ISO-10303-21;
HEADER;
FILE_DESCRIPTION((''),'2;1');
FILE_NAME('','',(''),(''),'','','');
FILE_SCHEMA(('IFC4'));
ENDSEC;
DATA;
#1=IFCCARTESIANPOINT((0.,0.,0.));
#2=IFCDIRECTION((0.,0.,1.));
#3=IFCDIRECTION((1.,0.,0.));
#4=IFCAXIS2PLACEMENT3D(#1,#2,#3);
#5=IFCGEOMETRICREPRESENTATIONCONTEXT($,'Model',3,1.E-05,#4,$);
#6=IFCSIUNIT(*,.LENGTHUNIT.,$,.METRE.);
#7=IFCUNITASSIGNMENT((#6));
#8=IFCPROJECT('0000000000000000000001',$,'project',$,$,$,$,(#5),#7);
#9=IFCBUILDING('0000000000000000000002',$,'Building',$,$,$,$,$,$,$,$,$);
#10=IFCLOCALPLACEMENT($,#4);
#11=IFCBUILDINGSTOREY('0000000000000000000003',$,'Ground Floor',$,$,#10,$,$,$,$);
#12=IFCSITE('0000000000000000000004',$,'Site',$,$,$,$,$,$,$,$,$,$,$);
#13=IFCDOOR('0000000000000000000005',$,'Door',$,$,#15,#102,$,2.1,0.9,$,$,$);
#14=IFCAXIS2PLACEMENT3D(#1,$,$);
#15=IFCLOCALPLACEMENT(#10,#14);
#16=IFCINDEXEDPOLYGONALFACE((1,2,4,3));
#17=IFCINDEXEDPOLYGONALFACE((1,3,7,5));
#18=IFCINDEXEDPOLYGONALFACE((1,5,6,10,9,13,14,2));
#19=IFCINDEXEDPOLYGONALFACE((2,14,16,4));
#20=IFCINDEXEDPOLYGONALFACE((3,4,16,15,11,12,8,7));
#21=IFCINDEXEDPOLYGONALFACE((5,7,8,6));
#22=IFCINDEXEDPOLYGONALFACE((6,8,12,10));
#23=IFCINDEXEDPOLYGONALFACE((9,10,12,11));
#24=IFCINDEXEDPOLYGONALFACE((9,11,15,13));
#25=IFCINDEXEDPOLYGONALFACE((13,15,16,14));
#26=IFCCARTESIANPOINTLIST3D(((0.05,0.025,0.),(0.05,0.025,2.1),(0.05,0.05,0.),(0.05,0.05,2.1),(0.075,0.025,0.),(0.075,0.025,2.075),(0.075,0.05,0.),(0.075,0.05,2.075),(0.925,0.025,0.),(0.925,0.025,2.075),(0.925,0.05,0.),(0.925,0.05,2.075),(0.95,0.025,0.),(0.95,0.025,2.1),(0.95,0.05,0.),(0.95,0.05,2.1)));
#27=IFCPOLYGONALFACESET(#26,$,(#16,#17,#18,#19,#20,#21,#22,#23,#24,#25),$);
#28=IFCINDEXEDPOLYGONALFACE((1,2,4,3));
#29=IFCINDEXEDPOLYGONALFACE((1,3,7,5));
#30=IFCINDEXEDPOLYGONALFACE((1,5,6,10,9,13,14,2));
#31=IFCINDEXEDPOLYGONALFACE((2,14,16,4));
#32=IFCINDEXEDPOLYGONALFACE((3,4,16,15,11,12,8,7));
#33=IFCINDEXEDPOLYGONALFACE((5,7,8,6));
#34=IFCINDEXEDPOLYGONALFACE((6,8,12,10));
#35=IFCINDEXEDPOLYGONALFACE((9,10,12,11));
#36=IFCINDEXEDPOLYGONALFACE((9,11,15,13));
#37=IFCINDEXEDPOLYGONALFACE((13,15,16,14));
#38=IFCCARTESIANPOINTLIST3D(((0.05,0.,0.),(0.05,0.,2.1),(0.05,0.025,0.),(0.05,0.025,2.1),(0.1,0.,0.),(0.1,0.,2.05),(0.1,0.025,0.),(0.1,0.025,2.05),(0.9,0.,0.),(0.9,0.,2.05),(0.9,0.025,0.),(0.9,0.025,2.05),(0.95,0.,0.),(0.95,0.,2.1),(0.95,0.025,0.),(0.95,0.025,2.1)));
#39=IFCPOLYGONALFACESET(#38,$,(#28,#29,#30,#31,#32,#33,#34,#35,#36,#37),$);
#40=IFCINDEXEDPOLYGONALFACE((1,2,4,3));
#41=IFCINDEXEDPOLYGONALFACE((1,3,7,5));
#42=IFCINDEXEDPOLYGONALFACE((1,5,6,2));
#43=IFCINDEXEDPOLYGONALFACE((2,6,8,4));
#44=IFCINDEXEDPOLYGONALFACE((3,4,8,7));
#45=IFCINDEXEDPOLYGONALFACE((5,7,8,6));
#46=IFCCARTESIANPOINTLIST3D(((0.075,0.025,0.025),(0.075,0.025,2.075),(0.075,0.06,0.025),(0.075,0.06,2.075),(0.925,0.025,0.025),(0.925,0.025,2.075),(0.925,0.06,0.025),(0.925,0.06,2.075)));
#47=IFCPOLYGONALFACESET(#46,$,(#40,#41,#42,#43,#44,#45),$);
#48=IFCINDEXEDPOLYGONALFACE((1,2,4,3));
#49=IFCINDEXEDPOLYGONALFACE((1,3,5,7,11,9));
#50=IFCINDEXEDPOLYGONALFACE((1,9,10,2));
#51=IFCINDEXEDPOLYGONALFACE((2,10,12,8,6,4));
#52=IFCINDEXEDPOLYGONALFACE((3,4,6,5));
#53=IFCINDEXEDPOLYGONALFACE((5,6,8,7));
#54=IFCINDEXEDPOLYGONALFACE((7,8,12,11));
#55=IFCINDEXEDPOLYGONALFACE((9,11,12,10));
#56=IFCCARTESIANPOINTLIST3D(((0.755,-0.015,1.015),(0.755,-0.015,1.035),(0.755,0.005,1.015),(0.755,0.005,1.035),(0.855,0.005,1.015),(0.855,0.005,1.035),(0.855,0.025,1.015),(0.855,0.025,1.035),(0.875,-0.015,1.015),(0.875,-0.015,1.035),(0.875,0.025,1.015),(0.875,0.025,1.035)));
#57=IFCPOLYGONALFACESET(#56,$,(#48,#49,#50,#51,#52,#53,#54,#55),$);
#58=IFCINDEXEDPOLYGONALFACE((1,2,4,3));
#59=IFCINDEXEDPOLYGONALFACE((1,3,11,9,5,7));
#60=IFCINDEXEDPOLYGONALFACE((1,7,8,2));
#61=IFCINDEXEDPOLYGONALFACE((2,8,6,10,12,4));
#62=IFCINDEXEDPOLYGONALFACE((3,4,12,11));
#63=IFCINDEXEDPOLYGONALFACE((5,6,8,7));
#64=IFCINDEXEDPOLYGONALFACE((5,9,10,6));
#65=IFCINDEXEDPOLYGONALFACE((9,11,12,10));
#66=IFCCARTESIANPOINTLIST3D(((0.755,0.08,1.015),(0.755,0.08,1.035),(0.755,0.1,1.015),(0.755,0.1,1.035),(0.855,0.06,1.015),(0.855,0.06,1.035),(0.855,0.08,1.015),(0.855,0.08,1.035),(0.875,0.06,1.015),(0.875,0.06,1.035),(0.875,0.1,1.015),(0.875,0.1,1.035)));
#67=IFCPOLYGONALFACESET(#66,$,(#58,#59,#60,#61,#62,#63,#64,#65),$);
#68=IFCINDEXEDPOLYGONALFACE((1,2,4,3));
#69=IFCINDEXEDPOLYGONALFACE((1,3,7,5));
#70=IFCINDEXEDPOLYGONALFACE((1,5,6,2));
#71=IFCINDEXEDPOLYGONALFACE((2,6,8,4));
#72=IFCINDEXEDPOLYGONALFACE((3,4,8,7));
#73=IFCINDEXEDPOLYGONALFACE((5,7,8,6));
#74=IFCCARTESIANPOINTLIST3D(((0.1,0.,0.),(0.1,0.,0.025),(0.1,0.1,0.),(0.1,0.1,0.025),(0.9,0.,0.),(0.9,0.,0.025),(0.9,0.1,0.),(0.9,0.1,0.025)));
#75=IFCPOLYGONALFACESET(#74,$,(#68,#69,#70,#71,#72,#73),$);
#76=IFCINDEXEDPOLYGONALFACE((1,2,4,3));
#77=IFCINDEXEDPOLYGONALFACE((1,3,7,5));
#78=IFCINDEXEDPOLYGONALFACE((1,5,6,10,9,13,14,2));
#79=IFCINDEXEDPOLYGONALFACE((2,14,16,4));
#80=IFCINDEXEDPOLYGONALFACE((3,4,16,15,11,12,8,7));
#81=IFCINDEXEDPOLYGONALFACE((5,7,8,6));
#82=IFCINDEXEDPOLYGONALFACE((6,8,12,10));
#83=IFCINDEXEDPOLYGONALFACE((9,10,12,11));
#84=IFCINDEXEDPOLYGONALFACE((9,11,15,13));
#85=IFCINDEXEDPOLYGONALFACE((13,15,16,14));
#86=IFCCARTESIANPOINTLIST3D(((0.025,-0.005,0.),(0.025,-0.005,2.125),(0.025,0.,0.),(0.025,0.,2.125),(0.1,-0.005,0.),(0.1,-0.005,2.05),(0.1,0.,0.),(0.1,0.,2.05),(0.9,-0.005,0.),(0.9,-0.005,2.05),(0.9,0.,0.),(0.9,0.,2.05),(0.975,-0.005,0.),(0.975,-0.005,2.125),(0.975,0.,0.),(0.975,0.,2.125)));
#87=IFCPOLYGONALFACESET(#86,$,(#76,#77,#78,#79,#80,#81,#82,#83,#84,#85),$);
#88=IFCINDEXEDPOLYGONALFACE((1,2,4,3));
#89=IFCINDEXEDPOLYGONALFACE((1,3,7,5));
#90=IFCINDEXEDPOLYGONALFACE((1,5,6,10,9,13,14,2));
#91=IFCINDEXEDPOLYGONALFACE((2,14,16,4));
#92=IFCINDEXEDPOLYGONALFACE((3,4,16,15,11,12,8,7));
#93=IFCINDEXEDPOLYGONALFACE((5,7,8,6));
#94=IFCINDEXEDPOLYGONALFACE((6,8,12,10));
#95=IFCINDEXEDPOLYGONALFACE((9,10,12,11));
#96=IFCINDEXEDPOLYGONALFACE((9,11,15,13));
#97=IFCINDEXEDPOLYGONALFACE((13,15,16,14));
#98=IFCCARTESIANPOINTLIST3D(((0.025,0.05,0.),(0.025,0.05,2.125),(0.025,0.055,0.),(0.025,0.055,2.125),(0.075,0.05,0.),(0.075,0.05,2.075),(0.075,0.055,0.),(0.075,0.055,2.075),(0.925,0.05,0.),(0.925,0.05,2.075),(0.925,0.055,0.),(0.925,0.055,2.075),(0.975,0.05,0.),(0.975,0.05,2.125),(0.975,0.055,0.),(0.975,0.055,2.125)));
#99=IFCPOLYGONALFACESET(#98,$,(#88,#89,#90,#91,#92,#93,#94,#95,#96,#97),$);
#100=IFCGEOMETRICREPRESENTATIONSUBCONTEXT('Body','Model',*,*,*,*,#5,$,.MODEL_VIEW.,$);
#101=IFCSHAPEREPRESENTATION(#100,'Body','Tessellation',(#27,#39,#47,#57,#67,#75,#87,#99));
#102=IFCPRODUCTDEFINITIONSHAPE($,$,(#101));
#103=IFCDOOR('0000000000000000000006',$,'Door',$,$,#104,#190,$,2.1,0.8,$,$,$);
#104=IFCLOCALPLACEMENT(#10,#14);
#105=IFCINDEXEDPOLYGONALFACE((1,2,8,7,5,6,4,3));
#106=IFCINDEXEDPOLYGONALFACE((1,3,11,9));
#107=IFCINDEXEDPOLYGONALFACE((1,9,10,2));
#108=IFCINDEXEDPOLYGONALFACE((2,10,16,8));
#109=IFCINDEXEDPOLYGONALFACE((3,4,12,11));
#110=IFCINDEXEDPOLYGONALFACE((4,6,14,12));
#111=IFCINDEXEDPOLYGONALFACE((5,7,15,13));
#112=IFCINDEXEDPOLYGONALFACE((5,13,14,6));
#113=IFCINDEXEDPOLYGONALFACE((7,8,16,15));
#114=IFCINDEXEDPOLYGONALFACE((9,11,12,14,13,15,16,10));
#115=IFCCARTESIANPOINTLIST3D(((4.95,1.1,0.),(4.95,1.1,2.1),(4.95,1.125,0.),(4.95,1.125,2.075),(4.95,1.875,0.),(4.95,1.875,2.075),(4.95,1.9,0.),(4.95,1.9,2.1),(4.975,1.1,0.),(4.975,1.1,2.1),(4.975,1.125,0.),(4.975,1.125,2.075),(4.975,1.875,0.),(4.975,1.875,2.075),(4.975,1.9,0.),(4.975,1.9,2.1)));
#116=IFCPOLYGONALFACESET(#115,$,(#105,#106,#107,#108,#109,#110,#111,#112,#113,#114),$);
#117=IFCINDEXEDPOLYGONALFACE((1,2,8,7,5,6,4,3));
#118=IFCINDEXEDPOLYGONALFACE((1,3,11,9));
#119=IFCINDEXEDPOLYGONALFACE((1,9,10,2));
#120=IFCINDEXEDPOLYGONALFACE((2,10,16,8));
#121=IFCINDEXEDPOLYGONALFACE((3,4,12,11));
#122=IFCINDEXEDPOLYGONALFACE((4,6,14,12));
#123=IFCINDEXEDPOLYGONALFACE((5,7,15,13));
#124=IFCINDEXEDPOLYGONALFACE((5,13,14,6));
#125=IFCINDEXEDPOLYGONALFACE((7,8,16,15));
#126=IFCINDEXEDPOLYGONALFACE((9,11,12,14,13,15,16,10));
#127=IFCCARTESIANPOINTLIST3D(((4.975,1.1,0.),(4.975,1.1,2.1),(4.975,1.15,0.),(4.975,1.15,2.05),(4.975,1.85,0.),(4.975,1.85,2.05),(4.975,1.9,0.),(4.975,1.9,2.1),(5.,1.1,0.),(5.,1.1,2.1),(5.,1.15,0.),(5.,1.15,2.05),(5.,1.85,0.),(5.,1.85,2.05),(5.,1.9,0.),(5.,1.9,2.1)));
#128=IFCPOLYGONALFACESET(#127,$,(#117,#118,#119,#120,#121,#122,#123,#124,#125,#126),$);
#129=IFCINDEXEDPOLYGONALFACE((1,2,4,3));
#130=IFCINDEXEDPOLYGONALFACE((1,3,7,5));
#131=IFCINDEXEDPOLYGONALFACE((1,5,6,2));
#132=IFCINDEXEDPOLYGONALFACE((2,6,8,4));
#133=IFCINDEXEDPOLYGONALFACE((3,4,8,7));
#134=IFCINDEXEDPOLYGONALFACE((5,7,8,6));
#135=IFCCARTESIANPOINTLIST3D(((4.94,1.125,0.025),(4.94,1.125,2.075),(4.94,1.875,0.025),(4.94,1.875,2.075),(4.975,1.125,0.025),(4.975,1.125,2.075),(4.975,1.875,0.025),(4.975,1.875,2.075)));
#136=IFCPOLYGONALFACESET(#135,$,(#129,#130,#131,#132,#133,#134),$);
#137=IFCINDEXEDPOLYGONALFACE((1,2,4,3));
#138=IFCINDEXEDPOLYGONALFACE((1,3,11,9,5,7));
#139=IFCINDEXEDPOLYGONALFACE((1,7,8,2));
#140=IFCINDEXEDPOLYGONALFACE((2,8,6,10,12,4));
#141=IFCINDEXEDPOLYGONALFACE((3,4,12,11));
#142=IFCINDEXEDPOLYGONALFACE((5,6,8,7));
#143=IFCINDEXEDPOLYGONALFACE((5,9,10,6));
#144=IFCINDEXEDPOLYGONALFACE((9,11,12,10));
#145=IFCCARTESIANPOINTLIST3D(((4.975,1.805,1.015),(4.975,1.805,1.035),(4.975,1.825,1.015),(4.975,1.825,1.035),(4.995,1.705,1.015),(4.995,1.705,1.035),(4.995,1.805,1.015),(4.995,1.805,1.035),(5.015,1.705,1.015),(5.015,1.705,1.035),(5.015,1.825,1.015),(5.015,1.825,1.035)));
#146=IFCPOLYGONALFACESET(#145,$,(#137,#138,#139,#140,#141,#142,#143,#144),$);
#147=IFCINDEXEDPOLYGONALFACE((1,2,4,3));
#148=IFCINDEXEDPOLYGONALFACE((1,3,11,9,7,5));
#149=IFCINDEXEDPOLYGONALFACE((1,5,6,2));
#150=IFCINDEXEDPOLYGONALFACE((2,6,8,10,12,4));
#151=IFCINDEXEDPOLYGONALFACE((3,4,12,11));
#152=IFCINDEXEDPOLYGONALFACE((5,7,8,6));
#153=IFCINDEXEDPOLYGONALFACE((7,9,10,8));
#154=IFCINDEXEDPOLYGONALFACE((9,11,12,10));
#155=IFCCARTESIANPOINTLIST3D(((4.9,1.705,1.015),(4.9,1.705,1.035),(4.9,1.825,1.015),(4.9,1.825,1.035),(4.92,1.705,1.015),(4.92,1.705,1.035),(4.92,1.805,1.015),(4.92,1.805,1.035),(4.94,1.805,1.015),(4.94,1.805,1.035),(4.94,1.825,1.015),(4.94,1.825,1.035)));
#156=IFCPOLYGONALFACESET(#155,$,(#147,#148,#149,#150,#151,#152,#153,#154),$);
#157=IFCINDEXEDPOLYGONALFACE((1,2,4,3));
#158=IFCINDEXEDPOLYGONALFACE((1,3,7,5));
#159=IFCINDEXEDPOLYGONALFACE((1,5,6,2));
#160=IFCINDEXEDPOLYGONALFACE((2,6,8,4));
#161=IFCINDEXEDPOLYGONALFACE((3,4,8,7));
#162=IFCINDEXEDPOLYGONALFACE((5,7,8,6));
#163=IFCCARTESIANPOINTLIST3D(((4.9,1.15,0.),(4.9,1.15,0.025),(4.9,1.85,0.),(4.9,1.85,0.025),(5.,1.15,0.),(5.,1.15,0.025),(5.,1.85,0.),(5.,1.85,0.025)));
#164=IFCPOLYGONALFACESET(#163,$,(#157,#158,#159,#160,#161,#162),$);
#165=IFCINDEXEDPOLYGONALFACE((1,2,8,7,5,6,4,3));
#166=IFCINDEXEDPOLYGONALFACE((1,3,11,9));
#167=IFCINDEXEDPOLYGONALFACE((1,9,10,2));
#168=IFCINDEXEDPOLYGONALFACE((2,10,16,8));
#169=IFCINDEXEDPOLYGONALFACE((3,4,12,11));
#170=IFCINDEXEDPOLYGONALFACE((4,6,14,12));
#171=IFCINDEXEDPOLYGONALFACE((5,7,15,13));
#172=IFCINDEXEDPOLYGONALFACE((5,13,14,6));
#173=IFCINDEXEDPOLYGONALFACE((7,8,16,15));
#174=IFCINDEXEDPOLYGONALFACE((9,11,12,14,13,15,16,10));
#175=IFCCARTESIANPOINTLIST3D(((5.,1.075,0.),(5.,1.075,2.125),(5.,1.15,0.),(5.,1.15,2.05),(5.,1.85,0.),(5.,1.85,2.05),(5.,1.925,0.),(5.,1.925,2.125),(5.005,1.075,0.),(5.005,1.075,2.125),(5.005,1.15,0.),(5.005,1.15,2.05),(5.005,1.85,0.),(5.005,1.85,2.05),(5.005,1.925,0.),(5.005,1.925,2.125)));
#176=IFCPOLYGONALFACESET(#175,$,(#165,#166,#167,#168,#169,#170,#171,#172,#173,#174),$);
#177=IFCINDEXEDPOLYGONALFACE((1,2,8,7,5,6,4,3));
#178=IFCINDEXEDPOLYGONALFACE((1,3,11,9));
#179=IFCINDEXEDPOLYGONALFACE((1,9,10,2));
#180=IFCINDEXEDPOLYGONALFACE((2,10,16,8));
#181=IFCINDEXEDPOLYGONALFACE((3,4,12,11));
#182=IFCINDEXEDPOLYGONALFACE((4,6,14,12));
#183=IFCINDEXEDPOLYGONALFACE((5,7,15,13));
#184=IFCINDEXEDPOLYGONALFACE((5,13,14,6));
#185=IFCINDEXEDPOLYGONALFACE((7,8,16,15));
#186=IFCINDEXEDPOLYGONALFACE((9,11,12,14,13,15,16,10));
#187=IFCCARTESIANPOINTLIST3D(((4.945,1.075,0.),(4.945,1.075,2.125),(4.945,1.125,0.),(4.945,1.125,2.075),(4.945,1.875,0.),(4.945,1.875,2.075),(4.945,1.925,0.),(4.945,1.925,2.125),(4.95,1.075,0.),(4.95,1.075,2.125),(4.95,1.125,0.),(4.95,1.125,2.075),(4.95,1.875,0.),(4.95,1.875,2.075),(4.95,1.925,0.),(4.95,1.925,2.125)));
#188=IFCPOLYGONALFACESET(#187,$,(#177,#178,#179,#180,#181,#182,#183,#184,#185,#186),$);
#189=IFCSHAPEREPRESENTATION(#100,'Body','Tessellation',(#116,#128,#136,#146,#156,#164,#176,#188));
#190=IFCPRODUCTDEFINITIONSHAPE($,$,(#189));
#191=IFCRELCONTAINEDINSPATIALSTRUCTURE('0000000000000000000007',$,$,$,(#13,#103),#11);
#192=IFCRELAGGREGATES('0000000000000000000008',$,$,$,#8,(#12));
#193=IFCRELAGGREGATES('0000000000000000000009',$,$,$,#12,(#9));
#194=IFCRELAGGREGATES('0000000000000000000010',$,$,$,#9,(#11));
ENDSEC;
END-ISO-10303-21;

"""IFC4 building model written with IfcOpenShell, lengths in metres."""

from ifc_helpers import new_model, si_unit, frame, origin_with_axes, place, context, subcontext, project, spatial, line, indexed_curve, outline, extrude, element, save


model = new_model("IFC4")

# Units and contexts
model_context = context("Model", 3, precision=1e-05, world=origin_with_axes())
body_context = subcontext(model_context, "Body", "Model", "MODEL_VIEW")
ifc_project = project(units=[si_unit("LENGTHUNIT", "METRE")], contexts=[model_context])

# Site, building, storey
site = spatial("IfcSite", under=ifc_project, Name="Site")
building = spatial("IfcBuilding", under=site, Name="Building")
storey_placement = place(None, origin_with_axes())
storey = spatial("IfcBuildingStorey", under=building, at=storey_placement, Name="Ground Floor")

# Doors
door_1_placement = place(storey_placement, frame((0.05, 0.0, 0.0), z_axis=(0.0, 0.0, 1.0), x_axis=(1.0, 0.0, 0.0)))
element("IfcDoor", 1, at=door_1_placement, inside=storey, Name="Door", OverallHeight=2.1, OverallWidth=0.9, context=body_context, shape_type="SweptSolid", body=[
    extrude(outline(indexed_curve([(0.0, 0.0), (0.0, 2.1), (0.9, 2.1), (0.9, 0.0), (0.875, 0.0), (0.875, 2.075), (0.025, 2.075), (0.025, 0.0)], segments=[line(1, 2, 3, 4, 5, 6, 7, 8, 1)])), frame((0.0, 0.025, 0.0), z_axis=(0.0, -1.0, 0.0), x_axis=(1.0, 0.0, 0.0)), (0.0, 0.0, -1.0), 0.025),
    extrude(outline(indexed_curve([(0.0, 0.0), (0.0, 2.1), (0.9, 2.1), (0.9, 0.0), (0.85, 0.0), (0.85, 2.05), (0.05, 2.05), (0.05, 0.0)], segments=[line(1, 2, 3, 4, 5, 6, 7, 8, 1)])), frame((0.0, 0.0, 0.0), z_axis=(0.0, -1.0, 0.0), x_axis=(1.0, 0.0, 0.0)), (0.0, 0.0, -1.0), 0.025),
    extrude(outline(indexed_curve([(0.0, 0.0), (0.85, 0.0), (0.85, 0.035), (0.0, 0.035)], segments=[line(1, 2, 3, 4, 1)])), frame((0.025, 0.025, 0.025), z_axis=(0.0, 0.0, 1.0), x_axis=(1.0, 0.0, 0.0)), (0.0, 0.0, 1.0), 2.05),
    extrude(outline(indexed_curve([(0.0, 0.0), (0.0, -0.04), (-0.12, -0.04), (-0.12, -0.02), (-0.02, -0.02), (-0.02, 0.0)], segments=[line(1, 2, 3, 4, 5, 6, 1)])), frame((0.825, 0.025, 1.015), z_axis=(0.0, 0.0, 1.0), x_axis=(1.0, 0.0, 0.0)), (0.0, 0.0, 1.0), 0.02),
    extrude(outline(indexed_curve([(0.0, 0.0), (0.0, 0.04), (-0.12, 0.04), (-0.12, 0.02), (-0.02, 0.02), (-0.02, 0.0)], segments=[line(1, 2, 3, 4, 5, 6, 1)])), frame((0.825, 0.06, 1.015), z_axis=(0.0, 0.0, 1.0), x_axis=(1.0, 0.0, 0.0)), (0.0, 0.0, 1.0), 0.02),
    extrude(outline(indexed_curve([(0.0, 0.0), (0.8, 0.0), (0.8, 0.1), (0.0, 0.1)], segments=[line(1, 2, 3, 4, 1)])), frame((0.05, 0.0, 0.0), z_axis=(0.0, 0.0, 1.0), x_axis=(1.0, 0.0, 0.0)), (0.0, 0.0, 1.0), 0.025),
    extrude(outline(indexed_curve([(0.0, 0.0), (0.0, 2.125), (0.95, 2.125), (0.95, 0.0), (0.875, 0.0), (0.875, 2.05), (0.075, 2.05), (0.075, 0.0)], segments=[line(1, 2, 3, 4, 5, 6, 7, 8, 1)])), frame((-0.025, -0.005, 0.0), z_axis=(0.0, -1.0, 0.0), x_axis=(1.0, 0.0, 0.0)), (0.0, 0.0, -1.0), 0.005),
    extrude(outline(indexed_curve([(0.0, 0.0), (0.0, 2.125), (0.95, 2.125), (0.95, 0.0), (0.9, 0.0), (0.9, 2.075), (0.05, 2.075), (0.05, 0.0)], segments=[line(1, 2, 3, 4, 5, 6, 7, 8, 1)])), frame((-0.025, 0.05, 0.0), z_axis=(0.0, -1.0, 0.0), x_axis=(1.0, 0.0, 0.0)), (0.0, 0.0, -1.0), 0.005),
])
door_2_placement = place(storey_placement, frame((5.0, 1.1, 0.0), z_axis=(0.0, 0.0, 1.0), x_axis=(0.0, 1.0, 0.0)))
element("IfcDoor", 2, at=door_2_placement, inside=storey, Name="Door", OverallHeight=2.1, OverallWidth=0.8, context=body_context, shape_type="SweptSolid", body=[
    extrude(outline(indexed_curve([(0.0, 0.0), (0.0, 2.1), (0.8, 2.1), (0.8, 0.0), (0.775, 0.0), (0.775, 2.075), (0.025, 2.075), (0.025, 0.0)], segments=[line(1, 2, 3, 4, 5, 6, 7, 8, 1)])), frame((0.0, 0.025, 0.0), z_axis=(0.0, -1.0, 0.0), x_axis=(1.0, 0.0, 0.0)), (0.0, 0.0, -1.0), 0.025),
    extrude(outline(indexed_curve([(0.0, 0.0), (0.0, 2.1), (0.8, 2.1), (0.8, 0.0), (0.75, 0.0), (0.75, 2.05), (0.05, 2.05), (0.05, 0.0)], segments=[line(1, 2, 3, 4, 5, 6, 7, 8, 1)])), frame((0.0, 0.0, 0.0), z_axis=(0.0, -1.0, 0.0), x_axis=(1.0, 0.0, 0.0)), (0.0, 0.0, -1.0), 0.025),
    extrude(outline(indexed_curve([(0.0, 0.0), (0.75, 0.0), (0.75, 0.035), (0.0, 0.035)], segments=[line(1, 2, 3, 4, 1)])), frame((0.025, 0.025, 0.025), z_axis=(0.0, 0.0, 1.0), x_axis=(1.0, 0.0, 0.0)), (0.0, 0.0, 1.0), 2.05),
    extrude(outline(indexed_curve([(0.0, 0.0), (0.0, -0.04), (-0.12, -0.04), (-0.12, -0.02), (-0.02, -0.02), (-0.02, 0.0)], segments=[line(1, 2, 3, 4, 5, 6, 1)])), frame((0.725, 0.025, 1.015), z_axis=(0.0, 0.0, 1.0), x_axis=(1.0, 0.0, 0.0)), (0.0, 0.0, 1.0), 0.02),
    extrude(outline(indexed_curve([(0.0, 0.0), (0.0, 0.04), (-0.12, 0.04), (-0.12, 0.02), (-0.02, 0.02), (-0.02, 0.0)], segments=[line(1, 2, 3, 4, 5, 6, 1)])), frame((0.725, 0.06, 1.015), z_axis=(0.0, 0.0, 1.0), x_axis=(1.0, 0.0, 0.0)), (0.0, 0.0, 1.0), 0.02),
    extrude(outline(indexed_curve([(0.0, 0.0), (0.7, 0.0), (0.7, 0.1), (0.0, 0.1)], segments=[line(1, 2, 3, 4, 1)])), frame((0.05, 0.0, 0.0), z_axis=(0.0, 0.0, 1.0), x_axis=(1.0, 0.0, 0.0)), (0.0, 0.0, 1.0), 0.025),
    extrude(outline(indexed_curve([(0.0, 0.0), (0.0, 2.125), (0.85, 2.125), (0.85, 0.0), (0.775, 0.0), (0.775, 2.05), (0.075, 2.05), (0.075, 0.0)], segments=[line(1, 2, 3, 4, 5, 6, 7, 8, 1)])), frame((-0.025, -0.005, 0.0), z_axis=(0.0, -1.0, 0.0), x_axis=(1.0, 0.0, 0.0)), (0.0, 0.0, -1.0), 0.005),
    extrude(outline(indexed_curve([(0.0, 0.0), (0.0, 2.125), (0.85, 2.125), (0.85, 0.0), (0.8, 0.0), (0.8, 2.075), (0.05, 2.075), (0.05, 0.0)], segments=[line(1, 2, 3, 4, 5, 6, 7, 8, 1)])), frame((-0.025, 0.05, 0.0), z_axis=(0.0, -1.0, 0.0), x_axis=(1.0, 0.0, 0.0)), (0.0, 0.0, -1.0), 0.005),
])

save(model, "model.ifc")
